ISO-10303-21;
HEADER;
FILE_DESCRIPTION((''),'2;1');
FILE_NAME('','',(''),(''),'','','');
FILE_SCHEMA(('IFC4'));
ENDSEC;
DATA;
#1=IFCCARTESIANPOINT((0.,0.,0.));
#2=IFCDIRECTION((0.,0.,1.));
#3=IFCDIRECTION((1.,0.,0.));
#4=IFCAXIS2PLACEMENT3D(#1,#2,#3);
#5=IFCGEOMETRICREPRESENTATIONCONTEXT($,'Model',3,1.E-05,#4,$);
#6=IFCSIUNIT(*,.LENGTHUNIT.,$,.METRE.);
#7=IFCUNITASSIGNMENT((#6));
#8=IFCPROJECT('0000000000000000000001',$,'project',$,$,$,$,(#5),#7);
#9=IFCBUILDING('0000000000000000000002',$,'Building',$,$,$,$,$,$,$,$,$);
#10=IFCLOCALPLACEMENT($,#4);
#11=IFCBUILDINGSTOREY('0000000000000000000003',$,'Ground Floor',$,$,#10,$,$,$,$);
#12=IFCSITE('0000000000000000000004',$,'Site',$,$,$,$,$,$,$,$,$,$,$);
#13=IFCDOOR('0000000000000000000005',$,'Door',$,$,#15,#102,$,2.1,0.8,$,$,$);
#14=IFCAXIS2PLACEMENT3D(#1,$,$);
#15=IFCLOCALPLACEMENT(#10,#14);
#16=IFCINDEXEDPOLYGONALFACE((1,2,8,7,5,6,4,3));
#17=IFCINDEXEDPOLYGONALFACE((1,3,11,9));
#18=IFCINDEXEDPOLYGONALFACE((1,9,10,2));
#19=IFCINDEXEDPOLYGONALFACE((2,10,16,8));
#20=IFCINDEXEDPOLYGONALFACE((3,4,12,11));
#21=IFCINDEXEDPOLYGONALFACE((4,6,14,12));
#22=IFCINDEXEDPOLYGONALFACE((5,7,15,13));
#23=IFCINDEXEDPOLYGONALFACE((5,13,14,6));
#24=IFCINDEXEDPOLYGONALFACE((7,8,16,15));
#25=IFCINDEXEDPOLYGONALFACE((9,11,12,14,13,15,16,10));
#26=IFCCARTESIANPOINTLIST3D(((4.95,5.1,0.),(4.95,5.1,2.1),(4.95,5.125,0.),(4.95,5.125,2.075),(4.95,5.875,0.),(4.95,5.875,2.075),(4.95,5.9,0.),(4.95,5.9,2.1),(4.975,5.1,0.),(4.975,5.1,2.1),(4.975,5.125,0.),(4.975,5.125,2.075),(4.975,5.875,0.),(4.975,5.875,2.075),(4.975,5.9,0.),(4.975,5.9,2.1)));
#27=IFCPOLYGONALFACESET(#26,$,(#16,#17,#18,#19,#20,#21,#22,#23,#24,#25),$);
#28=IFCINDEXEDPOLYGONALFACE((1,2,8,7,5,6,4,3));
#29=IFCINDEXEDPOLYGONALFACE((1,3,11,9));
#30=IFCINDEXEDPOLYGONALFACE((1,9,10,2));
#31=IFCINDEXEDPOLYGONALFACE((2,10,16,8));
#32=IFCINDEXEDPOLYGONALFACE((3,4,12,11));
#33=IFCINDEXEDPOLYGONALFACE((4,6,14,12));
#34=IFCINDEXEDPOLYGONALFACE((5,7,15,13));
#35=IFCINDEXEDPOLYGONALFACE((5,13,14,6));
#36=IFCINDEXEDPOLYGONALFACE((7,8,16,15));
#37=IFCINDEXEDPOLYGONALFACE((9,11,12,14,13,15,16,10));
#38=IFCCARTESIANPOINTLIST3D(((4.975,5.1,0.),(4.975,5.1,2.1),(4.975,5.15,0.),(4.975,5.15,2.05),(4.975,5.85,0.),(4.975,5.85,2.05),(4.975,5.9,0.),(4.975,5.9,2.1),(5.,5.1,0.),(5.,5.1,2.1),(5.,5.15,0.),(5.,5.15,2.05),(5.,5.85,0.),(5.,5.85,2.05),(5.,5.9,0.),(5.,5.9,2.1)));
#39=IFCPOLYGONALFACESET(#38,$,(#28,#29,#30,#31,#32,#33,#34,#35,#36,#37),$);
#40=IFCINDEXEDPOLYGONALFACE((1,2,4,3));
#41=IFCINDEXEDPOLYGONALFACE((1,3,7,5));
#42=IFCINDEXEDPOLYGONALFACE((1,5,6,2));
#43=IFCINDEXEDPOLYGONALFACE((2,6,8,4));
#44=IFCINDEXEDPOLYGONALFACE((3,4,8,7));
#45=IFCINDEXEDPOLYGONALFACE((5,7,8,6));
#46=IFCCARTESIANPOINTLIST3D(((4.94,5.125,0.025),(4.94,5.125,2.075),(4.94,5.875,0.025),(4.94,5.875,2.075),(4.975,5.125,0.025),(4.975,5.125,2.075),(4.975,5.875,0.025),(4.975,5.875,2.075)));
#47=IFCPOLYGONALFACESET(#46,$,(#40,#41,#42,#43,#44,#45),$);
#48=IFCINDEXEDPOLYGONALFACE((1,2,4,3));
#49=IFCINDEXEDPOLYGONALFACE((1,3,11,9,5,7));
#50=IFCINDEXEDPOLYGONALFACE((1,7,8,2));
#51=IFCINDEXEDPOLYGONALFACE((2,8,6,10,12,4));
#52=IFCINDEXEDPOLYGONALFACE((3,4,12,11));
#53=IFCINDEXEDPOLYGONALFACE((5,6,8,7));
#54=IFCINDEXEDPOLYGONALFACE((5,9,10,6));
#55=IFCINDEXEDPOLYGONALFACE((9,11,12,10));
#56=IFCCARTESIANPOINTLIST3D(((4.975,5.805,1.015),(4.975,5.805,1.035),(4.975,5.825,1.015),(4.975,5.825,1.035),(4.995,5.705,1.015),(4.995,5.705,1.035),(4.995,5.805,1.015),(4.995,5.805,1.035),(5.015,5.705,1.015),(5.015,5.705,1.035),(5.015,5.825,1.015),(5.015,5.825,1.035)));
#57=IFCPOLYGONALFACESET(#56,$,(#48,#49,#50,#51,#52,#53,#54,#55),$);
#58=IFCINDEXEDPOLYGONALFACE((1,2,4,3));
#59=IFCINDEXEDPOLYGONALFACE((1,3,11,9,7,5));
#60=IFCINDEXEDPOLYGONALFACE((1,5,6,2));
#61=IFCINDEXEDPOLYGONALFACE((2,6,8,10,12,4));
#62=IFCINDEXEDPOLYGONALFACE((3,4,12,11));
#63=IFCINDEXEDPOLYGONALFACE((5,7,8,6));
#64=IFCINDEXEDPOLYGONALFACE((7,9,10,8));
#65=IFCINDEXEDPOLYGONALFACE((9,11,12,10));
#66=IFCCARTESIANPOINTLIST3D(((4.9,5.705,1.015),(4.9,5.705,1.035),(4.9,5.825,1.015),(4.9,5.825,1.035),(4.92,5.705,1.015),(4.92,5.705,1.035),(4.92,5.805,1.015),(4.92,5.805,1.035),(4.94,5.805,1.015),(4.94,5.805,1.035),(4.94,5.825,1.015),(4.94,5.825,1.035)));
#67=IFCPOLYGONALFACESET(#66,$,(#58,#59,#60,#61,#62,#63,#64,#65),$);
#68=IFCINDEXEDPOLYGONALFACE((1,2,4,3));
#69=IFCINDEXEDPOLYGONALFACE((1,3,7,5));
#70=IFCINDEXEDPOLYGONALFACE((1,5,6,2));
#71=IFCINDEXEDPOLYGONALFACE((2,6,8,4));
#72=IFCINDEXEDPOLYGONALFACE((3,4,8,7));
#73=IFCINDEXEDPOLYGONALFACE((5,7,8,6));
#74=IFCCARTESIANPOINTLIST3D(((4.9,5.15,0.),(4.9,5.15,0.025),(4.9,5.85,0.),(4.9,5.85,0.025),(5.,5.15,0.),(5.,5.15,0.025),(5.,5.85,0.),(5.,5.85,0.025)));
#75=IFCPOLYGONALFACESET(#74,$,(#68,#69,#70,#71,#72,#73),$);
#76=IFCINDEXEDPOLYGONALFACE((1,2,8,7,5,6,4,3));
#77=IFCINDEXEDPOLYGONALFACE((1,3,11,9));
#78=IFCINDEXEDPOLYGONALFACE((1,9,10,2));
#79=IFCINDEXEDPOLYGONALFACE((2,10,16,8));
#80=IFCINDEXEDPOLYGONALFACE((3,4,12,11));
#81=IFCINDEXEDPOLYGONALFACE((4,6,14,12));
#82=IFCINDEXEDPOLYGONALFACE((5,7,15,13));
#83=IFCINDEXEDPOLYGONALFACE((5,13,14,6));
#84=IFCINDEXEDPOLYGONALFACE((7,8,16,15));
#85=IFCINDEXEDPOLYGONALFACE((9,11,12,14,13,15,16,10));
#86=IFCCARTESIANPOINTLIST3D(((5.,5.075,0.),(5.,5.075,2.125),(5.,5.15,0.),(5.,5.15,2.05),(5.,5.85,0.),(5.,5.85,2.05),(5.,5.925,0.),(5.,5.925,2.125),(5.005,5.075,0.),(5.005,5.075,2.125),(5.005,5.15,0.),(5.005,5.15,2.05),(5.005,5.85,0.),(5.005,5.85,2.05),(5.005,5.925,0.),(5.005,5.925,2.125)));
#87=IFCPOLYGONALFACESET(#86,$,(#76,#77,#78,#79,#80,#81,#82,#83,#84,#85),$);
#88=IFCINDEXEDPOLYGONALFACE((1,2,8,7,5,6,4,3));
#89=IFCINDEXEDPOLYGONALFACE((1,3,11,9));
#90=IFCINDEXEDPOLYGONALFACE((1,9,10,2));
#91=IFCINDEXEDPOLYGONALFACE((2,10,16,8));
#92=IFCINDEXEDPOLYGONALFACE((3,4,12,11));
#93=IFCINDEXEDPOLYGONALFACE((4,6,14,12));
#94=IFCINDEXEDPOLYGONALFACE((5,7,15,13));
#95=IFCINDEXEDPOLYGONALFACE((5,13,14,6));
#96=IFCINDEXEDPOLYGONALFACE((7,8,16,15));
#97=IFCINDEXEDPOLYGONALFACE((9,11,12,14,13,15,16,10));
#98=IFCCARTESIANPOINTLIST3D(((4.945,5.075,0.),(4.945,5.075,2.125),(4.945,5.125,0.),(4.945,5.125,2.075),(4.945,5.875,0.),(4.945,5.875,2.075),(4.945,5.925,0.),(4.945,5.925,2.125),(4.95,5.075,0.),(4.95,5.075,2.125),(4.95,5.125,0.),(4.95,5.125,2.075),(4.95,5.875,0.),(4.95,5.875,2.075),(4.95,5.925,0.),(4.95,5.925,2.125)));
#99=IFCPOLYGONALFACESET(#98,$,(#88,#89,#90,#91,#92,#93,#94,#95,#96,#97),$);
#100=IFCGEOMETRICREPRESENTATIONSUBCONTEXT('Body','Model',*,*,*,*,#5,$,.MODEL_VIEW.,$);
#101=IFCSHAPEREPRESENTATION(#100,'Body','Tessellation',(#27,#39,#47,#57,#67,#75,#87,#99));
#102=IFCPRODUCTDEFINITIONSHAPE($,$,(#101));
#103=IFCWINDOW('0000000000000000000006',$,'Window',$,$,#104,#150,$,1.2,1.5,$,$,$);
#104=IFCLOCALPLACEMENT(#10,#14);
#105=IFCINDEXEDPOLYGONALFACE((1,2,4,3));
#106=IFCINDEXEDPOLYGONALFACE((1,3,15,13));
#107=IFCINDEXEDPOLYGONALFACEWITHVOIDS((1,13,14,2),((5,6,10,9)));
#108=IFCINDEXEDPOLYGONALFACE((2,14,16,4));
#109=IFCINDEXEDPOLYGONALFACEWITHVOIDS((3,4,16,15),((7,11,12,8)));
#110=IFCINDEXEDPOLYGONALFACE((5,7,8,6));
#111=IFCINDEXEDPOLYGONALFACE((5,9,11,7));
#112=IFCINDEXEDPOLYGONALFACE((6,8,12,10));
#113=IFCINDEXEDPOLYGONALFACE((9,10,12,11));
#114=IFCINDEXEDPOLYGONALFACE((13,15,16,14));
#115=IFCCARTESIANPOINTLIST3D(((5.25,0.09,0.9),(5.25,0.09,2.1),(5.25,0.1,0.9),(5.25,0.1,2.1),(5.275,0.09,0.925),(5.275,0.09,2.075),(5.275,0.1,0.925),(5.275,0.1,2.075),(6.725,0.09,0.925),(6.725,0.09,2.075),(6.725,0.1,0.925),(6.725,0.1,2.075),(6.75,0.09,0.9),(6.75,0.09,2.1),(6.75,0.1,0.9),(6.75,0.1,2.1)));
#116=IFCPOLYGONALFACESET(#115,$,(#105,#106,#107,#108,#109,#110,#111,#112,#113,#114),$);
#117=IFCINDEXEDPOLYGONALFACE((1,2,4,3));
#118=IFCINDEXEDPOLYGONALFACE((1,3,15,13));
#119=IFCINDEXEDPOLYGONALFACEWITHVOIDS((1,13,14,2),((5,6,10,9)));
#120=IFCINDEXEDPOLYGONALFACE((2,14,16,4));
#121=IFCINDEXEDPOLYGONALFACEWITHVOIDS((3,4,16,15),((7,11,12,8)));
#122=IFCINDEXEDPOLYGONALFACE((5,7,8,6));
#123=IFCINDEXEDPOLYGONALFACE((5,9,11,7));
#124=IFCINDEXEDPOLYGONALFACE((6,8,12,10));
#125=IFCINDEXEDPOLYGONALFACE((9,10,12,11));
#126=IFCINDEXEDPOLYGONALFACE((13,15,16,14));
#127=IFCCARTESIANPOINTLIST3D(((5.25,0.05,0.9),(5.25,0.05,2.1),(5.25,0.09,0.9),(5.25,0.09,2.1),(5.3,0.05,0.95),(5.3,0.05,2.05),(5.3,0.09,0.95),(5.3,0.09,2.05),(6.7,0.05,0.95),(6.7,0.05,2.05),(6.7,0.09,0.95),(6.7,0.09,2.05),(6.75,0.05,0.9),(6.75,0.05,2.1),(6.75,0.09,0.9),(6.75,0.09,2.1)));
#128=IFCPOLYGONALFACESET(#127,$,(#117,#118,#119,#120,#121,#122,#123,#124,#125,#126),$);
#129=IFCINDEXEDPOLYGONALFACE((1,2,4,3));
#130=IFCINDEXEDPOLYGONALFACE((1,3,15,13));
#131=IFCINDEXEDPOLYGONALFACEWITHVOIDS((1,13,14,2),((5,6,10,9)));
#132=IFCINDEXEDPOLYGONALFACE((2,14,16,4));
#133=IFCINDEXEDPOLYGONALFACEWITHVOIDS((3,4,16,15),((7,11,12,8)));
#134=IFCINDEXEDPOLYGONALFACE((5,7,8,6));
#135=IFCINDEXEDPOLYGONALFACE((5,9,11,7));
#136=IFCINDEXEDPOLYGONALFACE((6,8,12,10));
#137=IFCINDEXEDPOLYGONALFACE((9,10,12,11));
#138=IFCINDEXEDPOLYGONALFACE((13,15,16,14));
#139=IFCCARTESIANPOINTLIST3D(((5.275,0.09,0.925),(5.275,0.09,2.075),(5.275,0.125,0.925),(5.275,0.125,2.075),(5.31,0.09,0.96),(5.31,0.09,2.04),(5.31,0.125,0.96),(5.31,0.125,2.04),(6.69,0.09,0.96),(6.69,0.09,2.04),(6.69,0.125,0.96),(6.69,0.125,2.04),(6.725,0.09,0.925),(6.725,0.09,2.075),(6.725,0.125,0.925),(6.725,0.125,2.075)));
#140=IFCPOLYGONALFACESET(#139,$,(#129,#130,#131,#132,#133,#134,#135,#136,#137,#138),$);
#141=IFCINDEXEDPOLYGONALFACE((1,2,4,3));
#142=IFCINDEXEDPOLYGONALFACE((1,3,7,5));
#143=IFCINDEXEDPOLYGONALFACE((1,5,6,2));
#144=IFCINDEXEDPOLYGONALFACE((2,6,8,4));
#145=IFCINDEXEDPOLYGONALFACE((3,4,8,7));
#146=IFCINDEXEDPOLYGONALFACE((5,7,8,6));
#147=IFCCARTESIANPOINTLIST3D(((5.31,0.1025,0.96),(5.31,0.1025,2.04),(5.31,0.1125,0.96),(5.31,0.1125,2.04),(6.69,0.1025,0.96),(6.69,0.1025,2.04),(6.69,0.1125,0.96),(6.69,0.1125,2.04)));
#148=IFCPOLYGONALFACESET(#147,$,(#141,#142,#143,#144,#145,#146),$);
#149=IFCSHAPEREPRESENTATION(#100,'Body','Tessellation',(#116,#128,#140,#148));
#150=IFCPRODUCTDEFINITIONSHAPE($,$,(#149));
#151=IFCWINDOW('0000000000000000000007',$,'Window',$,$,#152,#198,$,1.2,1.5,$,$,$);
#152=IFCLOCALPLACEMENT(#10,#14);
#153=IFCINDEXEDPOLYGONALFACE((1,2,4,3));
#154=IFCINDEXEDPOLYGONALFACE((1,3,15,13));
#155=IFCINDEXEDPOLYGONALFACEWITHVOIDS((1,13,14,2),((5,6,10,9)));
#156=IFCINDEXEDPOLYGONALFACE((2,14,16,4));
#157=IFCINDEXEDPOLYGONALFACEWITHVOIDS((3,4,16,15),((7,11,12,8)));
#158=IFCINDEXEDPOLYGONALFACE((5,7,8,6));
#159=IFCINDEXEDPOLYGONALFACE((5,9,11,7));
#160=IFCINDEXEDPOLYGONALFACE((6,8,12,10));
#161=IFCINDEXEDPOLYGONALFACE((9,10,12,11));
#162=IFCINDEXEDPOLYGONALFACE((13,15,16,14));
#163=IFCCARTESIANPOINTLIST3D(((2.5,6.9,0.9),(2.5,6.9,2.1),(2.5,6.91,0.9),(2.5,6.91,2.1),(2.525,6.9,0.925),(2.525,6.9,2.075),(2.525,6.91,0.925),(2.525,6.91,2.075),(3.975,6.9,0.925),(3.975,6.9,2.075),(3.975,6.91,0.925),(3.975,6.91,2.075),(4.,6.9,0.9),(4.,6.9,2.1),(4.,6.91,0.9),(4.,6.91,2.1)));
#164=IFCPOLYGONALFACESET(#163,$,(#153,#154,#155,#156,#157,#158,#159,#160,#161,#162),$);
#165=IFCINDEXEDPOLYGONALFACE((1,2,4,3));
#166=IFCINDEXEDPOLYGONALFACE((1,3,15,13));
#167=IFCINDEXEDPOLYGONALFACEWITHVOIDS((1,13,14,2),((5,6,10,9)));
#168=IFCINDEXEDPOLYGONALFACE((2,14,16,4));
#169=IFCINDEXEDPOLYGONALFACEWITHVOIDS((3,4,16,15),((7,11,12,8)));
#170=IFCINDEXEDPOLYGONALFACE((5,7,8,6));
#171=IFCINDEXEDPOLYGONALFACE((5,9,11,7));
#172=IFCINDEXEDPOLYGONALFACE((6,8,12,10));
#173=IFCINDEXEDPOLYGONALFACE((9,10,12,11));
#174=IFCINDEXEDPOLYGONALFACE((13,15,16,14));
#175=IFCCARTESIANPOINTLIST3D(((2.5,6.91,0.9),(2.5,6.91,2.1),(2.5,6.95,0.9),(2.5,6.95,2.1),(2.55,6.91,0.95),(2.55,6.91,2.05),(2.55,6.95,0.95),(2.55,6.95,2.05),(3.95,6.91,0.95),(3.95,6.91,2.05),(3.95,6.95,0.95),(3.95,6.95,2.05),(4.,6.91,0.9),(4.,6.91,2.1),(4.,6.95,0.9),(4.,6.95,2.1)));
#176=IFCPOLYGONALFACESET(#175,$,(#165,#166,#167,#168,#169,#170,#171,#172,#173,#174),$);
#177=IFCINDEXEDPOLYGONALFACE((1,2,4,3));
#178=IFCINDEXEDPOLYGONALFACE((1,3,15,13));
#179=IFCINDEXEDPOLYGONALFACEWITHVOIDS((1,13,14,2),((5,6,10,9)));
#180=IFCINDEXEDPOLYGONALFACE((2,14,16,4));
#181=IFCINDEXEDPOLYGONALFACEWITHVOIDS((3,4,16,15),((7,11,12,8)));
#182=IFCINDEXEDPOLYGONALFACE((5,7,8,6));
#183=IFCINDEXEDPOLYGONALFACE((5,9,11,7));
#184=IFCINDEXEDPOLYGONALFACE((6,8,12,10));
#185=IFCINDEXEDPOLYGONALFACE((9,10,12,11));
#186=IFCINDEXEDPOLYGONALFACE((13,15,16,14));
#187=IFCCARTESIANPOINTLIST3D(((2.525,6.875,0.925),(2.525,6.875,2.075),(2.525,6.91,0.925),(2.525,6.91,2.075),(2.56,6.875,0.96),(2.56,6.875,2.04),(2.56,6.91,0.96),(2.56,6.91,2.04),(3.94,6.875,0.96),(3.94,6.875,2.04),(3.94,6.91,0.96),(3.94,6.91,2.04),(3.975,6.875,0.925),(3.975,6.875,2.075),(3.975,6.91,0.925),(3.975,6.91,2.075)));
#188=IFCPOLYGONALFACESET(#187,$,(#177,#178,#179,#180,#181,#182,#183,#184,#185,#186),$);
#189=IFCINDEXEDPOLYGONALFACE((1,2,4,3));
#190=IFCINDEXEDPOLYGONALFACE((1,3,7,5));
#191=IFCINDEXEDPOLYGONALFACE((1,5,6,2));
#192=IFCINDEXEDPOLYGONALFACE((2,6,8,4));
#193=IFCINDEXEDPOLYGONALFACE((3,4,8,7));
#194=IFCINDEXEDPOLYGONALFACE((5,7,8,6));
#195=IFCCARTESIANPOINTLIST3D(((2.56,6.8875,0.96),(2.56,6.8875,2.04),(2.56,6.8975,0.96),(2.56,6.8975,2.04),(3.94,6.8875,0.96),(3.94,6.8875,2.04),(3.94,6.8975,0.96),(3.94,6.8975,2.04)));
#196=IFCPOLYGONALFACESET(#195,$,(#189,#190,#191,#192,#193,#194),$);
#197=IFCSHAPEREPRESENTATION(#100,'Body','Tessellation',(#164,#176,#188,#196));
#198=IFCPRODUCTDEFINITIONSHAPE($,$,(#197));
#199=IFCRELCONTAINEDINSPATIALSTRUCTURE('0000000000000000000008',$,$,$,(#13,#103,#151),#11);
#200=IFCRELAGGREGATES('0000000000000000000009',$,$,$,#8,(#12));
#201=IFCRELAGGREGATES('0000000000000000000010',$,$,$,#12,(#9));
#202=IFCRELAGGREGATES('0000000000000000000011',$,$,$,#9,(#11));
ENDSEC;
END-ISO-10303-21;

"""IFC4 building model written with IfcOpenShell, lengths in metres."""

from ifc_helpers import new_model, si_unit, frame, origin_with_axes, place, context, subcontext, project, spatial, line, indexed_curve, outline, extrude, element, save


model = new_model("IFC4")

# Units and contexts
model_context = context("Model", 3, precision=1e-05, world=origin_with_axes())
body_context = subcontext(model_context, "Body", "Model", "MODEL_VIEW")
ifc_project = project(units=[si_unit("LENGTHUNIT", "METRE")], contexts=[model_context])

# Site, building, storey
site = spatial("IfcSite", under=ifc_project, Name="Site")
building = spatial("IfcBuilding", under=site, Name="Building")
storey_placement = place(None, origin_with_axes())
storey = spatial("IfcBuildingStorey", under=building, at=storey_placement, Name="Ground Floor")

# Door
door_1_placement = place(storey_placement, frame((5.0, 5.1, 0.0), z_axis=(0.0, 0.0, 1.0), x_axis=(0.0, 1.0, 0.0)))
element("IfcDoor", 1, at=door_1_placement, inside=storey, Name="Door", OverallHeight=2.1, OverallWidth=0.8, context=body_context, shape_type="SweptSolid", body=[
    extrude(outline(indexed_curve([(0.0, 0.0), (0.0, 2.1), (0.8, 2.1), (0.8, 0.0), (0.775, 0.0), (0.775, 2.075), (0.025, 2.075), (0.025, 0.0)], segments=[line(1, 2, 3, 4, 5, 6, 7, 8, 1)])), frame((0.0, 0.025, 0.0), z_axis=(0.0, -1.0, 0.0), x_axis=(1.0, 0.0, 0.0)), (0.0, 0.0, -1.0), 0.025),
    extrude(outline(indexed_curve([(0.0, 0.0), (0.0, 2.1), (0.8, 2.1), (0.8, 0.0), (0.75, 0.0), (0.75, 2.05), (0.05, 2.05), (0.05, 0.0)], segments=[line(1, 2, 3, 4, 5, 6, 7, 8, 1)])), frame((0.0, 0.0, 0.0), z_axis=(0.0, -1.0, 0.0), x_axis=(1.0, 0.0, 0.0)), (0.0, 0.0, -1.0), 0.025),
    extrude(outline(indexed_curve([(0.0, 0.0), (0.75, 0.0), (0.75, 0.035), (0.0, 0.035)], segments=[line(1, 2, 3, 4, 1)])), frame((0.025, 0.025, 0.025), z_axis=(0.0, 0.0, 1.0), x_axis=(1.0, 0.0, 0.0)), (0.0, 0.0, 1.0), 2.05),
    extrude(outline(indexed_curve([(0.0, 0.0), (0.0, -0.04), (-0.12, -0.04), (-0.12, -0.02), (-0.02, -0.02), (-0.02, 0.0)], segments=[line(1, 2, 3, 4, 5, 6, 1)])), frame((0.725, 0.025, 1.015), z_axis=(0.0, 0.0, 1.0), x_axis=(1.0, 0.0, 0.0)), (0.0, 0.0, 1.0), 0.02),
    extrude(outline(indexed_curve([(0.0, 0.0), (0.0, 0.04), (-0.12, 0.04), (-0.12, 0.02), (-0.02, 0.02), (-0.02, 0.0)], segments=[line(1, 2, 3, 4, 5, 6, 1)])), frame((0.725, 0.06, 1.015), z_axis=(0.0, 0.0, 1.0), x_axis=(1.0, 0.0, 0.0)), (0.0, 0.0, 1.0), 0.02),
    extrude(outline(indexed_curve([(0.0, 0.0), (0.7, 0.0), (0.7, 0.1), (0.0, 0.1)], segments=[line(1, 2, 3, 4, 1)])), frame((0.05, 0.0, 0.0), z_axis=(0.0, 0.0, 1.0), x_axis=(1.0, 0.0, 0.0)), (0.0, 0.0, 1.0), 0.025),
    extrude(outline(indexed_curve([(0.0, 0.0), (0.0, 2.125), (0.85, 2.125), (0.85, 0.0), (0.775, 0.0), (0.775, 2.05), (0.075, 2.05), (0.075, 0.0)], segments=[line(1, 2, 3, 4, 5, 6, 7, 8, 1)])), frame((-0.025, -0.005, 0.0), z_axis=(0.0, -1.0, 0.0), x_axis=(1.0, 0.0, 0.0)), (0.0, 0.0, -1.0), 0.005),
    extrude(outline(indexed_curve([(0.0, 0.0), (0.0, 2.125), (0.85, 2.125), (0.85, 0.0), (0.8, 0.0), (0.8, 2.075), (0.05, 2.075), (0.05, 0.0)], segments=[line(1, 2, 3, 4, 5, 6, 7, 8, 1)])), frame((-0.025, 0.05, 0.0), z_axis=(0.0, -1.0, 0.0), x_axis=(1.0, 0.0, 0.0)), (0.0, 0.0, -1.0), 0.005),
])

# Windows
for number, where, z_axis, x_axis, name in (
    (2, (5.25, 0.0, 0.9), (0.0, 0.0, 1.0), (1.0, 0.0, 0.0), "Window"),
    (3, (4.0, 7.0, 0.9), (0.0, 0.0, 1.0), (-1.0, 0.0, 0.0), "Window"),
):
    element("IfcWindow", number, at=place(storey_placement, frame(where, z_axis=z_axis, x_axis=x_axis)), inside=storey, Name=name, OverallHeight=1.2, OverallWidth=1.5, context=body_context, shape_type="SweptSolid", body=[
        extrude(outline(indexed_curve([(0.0, 0.0), (1.5, 0.0), (1.5, 1.2), (0.0, 1.2)], segments=[line(1, 2, 3, 4, 1)]), holes=[indexed_curve([(0.025, 0.025), (1.475, 0.025), (1.475, 1.175), (0.025, 1.175)], segments=[line(1, 2, 3, 4, 1)])]), frame((0.0, 0.09, 0.0), z_axis=(0.0, -1.0, 0.0), x_axis=(1.0, 0.0, 0.0)), (0.0, 0.0, -1.0), 0.01),
        extrude(outline(indexed_curve([(0.0, 0.0), (1.5, 0.0), (1.5, 1.2), (0.0, 1.2)], segments=[line(1, 2, 3, 4, 1)]), holes=[indexed_curve([(0.05, 0.05), (1.45, 0.05), (1.45, 1.15), (0.05, 1.15)], segments=[line(1, 2, 3, 4, 1)])]), frame((0.0, 0.05, 0.0), z_axis=(0.0, -1.0, 0.0), x_axis=(1.0, 0.0, 0.0)), (0.0, 0.0, -1.0), 0.04),
        extrude(outline(indexed_curve([(0.0, 0.0), (1.45, 0.0), (1.45, 1.15), (0.0, 1.15)], segments=[line(1, 2, 3, 4, 1)]), holes=[indexed_curve([(0.035, 0.035), (1.415, 0.035), (1.415, 1.115), (0.035, 1.115)], segments=[line(1, 2, 3, 4, 1)])]), frame((0.025, 0.09, 0.025), z_axis=(0.0, -1.0, 0.0), x_axis=(1.0, 0.0, 0.0)), (0.0, 0.0, -1.0), 0.035),
        extrude(outline(indexed_curve([(0.035, 0.035), (1.415, 0.035), (1.415, 1.115), (0.035, 1.115)], segments=[line(1, 2, 3, 4, 1)])), frame((0.025, 0.1025, 0.025), z_axis=(0.0, -1.0, 0.0), x_axis=(1.0, 0.0, 0.0)), (0.0, 0.0, -1.0), 0.01),
    ])

save(model, "model.ifc")
